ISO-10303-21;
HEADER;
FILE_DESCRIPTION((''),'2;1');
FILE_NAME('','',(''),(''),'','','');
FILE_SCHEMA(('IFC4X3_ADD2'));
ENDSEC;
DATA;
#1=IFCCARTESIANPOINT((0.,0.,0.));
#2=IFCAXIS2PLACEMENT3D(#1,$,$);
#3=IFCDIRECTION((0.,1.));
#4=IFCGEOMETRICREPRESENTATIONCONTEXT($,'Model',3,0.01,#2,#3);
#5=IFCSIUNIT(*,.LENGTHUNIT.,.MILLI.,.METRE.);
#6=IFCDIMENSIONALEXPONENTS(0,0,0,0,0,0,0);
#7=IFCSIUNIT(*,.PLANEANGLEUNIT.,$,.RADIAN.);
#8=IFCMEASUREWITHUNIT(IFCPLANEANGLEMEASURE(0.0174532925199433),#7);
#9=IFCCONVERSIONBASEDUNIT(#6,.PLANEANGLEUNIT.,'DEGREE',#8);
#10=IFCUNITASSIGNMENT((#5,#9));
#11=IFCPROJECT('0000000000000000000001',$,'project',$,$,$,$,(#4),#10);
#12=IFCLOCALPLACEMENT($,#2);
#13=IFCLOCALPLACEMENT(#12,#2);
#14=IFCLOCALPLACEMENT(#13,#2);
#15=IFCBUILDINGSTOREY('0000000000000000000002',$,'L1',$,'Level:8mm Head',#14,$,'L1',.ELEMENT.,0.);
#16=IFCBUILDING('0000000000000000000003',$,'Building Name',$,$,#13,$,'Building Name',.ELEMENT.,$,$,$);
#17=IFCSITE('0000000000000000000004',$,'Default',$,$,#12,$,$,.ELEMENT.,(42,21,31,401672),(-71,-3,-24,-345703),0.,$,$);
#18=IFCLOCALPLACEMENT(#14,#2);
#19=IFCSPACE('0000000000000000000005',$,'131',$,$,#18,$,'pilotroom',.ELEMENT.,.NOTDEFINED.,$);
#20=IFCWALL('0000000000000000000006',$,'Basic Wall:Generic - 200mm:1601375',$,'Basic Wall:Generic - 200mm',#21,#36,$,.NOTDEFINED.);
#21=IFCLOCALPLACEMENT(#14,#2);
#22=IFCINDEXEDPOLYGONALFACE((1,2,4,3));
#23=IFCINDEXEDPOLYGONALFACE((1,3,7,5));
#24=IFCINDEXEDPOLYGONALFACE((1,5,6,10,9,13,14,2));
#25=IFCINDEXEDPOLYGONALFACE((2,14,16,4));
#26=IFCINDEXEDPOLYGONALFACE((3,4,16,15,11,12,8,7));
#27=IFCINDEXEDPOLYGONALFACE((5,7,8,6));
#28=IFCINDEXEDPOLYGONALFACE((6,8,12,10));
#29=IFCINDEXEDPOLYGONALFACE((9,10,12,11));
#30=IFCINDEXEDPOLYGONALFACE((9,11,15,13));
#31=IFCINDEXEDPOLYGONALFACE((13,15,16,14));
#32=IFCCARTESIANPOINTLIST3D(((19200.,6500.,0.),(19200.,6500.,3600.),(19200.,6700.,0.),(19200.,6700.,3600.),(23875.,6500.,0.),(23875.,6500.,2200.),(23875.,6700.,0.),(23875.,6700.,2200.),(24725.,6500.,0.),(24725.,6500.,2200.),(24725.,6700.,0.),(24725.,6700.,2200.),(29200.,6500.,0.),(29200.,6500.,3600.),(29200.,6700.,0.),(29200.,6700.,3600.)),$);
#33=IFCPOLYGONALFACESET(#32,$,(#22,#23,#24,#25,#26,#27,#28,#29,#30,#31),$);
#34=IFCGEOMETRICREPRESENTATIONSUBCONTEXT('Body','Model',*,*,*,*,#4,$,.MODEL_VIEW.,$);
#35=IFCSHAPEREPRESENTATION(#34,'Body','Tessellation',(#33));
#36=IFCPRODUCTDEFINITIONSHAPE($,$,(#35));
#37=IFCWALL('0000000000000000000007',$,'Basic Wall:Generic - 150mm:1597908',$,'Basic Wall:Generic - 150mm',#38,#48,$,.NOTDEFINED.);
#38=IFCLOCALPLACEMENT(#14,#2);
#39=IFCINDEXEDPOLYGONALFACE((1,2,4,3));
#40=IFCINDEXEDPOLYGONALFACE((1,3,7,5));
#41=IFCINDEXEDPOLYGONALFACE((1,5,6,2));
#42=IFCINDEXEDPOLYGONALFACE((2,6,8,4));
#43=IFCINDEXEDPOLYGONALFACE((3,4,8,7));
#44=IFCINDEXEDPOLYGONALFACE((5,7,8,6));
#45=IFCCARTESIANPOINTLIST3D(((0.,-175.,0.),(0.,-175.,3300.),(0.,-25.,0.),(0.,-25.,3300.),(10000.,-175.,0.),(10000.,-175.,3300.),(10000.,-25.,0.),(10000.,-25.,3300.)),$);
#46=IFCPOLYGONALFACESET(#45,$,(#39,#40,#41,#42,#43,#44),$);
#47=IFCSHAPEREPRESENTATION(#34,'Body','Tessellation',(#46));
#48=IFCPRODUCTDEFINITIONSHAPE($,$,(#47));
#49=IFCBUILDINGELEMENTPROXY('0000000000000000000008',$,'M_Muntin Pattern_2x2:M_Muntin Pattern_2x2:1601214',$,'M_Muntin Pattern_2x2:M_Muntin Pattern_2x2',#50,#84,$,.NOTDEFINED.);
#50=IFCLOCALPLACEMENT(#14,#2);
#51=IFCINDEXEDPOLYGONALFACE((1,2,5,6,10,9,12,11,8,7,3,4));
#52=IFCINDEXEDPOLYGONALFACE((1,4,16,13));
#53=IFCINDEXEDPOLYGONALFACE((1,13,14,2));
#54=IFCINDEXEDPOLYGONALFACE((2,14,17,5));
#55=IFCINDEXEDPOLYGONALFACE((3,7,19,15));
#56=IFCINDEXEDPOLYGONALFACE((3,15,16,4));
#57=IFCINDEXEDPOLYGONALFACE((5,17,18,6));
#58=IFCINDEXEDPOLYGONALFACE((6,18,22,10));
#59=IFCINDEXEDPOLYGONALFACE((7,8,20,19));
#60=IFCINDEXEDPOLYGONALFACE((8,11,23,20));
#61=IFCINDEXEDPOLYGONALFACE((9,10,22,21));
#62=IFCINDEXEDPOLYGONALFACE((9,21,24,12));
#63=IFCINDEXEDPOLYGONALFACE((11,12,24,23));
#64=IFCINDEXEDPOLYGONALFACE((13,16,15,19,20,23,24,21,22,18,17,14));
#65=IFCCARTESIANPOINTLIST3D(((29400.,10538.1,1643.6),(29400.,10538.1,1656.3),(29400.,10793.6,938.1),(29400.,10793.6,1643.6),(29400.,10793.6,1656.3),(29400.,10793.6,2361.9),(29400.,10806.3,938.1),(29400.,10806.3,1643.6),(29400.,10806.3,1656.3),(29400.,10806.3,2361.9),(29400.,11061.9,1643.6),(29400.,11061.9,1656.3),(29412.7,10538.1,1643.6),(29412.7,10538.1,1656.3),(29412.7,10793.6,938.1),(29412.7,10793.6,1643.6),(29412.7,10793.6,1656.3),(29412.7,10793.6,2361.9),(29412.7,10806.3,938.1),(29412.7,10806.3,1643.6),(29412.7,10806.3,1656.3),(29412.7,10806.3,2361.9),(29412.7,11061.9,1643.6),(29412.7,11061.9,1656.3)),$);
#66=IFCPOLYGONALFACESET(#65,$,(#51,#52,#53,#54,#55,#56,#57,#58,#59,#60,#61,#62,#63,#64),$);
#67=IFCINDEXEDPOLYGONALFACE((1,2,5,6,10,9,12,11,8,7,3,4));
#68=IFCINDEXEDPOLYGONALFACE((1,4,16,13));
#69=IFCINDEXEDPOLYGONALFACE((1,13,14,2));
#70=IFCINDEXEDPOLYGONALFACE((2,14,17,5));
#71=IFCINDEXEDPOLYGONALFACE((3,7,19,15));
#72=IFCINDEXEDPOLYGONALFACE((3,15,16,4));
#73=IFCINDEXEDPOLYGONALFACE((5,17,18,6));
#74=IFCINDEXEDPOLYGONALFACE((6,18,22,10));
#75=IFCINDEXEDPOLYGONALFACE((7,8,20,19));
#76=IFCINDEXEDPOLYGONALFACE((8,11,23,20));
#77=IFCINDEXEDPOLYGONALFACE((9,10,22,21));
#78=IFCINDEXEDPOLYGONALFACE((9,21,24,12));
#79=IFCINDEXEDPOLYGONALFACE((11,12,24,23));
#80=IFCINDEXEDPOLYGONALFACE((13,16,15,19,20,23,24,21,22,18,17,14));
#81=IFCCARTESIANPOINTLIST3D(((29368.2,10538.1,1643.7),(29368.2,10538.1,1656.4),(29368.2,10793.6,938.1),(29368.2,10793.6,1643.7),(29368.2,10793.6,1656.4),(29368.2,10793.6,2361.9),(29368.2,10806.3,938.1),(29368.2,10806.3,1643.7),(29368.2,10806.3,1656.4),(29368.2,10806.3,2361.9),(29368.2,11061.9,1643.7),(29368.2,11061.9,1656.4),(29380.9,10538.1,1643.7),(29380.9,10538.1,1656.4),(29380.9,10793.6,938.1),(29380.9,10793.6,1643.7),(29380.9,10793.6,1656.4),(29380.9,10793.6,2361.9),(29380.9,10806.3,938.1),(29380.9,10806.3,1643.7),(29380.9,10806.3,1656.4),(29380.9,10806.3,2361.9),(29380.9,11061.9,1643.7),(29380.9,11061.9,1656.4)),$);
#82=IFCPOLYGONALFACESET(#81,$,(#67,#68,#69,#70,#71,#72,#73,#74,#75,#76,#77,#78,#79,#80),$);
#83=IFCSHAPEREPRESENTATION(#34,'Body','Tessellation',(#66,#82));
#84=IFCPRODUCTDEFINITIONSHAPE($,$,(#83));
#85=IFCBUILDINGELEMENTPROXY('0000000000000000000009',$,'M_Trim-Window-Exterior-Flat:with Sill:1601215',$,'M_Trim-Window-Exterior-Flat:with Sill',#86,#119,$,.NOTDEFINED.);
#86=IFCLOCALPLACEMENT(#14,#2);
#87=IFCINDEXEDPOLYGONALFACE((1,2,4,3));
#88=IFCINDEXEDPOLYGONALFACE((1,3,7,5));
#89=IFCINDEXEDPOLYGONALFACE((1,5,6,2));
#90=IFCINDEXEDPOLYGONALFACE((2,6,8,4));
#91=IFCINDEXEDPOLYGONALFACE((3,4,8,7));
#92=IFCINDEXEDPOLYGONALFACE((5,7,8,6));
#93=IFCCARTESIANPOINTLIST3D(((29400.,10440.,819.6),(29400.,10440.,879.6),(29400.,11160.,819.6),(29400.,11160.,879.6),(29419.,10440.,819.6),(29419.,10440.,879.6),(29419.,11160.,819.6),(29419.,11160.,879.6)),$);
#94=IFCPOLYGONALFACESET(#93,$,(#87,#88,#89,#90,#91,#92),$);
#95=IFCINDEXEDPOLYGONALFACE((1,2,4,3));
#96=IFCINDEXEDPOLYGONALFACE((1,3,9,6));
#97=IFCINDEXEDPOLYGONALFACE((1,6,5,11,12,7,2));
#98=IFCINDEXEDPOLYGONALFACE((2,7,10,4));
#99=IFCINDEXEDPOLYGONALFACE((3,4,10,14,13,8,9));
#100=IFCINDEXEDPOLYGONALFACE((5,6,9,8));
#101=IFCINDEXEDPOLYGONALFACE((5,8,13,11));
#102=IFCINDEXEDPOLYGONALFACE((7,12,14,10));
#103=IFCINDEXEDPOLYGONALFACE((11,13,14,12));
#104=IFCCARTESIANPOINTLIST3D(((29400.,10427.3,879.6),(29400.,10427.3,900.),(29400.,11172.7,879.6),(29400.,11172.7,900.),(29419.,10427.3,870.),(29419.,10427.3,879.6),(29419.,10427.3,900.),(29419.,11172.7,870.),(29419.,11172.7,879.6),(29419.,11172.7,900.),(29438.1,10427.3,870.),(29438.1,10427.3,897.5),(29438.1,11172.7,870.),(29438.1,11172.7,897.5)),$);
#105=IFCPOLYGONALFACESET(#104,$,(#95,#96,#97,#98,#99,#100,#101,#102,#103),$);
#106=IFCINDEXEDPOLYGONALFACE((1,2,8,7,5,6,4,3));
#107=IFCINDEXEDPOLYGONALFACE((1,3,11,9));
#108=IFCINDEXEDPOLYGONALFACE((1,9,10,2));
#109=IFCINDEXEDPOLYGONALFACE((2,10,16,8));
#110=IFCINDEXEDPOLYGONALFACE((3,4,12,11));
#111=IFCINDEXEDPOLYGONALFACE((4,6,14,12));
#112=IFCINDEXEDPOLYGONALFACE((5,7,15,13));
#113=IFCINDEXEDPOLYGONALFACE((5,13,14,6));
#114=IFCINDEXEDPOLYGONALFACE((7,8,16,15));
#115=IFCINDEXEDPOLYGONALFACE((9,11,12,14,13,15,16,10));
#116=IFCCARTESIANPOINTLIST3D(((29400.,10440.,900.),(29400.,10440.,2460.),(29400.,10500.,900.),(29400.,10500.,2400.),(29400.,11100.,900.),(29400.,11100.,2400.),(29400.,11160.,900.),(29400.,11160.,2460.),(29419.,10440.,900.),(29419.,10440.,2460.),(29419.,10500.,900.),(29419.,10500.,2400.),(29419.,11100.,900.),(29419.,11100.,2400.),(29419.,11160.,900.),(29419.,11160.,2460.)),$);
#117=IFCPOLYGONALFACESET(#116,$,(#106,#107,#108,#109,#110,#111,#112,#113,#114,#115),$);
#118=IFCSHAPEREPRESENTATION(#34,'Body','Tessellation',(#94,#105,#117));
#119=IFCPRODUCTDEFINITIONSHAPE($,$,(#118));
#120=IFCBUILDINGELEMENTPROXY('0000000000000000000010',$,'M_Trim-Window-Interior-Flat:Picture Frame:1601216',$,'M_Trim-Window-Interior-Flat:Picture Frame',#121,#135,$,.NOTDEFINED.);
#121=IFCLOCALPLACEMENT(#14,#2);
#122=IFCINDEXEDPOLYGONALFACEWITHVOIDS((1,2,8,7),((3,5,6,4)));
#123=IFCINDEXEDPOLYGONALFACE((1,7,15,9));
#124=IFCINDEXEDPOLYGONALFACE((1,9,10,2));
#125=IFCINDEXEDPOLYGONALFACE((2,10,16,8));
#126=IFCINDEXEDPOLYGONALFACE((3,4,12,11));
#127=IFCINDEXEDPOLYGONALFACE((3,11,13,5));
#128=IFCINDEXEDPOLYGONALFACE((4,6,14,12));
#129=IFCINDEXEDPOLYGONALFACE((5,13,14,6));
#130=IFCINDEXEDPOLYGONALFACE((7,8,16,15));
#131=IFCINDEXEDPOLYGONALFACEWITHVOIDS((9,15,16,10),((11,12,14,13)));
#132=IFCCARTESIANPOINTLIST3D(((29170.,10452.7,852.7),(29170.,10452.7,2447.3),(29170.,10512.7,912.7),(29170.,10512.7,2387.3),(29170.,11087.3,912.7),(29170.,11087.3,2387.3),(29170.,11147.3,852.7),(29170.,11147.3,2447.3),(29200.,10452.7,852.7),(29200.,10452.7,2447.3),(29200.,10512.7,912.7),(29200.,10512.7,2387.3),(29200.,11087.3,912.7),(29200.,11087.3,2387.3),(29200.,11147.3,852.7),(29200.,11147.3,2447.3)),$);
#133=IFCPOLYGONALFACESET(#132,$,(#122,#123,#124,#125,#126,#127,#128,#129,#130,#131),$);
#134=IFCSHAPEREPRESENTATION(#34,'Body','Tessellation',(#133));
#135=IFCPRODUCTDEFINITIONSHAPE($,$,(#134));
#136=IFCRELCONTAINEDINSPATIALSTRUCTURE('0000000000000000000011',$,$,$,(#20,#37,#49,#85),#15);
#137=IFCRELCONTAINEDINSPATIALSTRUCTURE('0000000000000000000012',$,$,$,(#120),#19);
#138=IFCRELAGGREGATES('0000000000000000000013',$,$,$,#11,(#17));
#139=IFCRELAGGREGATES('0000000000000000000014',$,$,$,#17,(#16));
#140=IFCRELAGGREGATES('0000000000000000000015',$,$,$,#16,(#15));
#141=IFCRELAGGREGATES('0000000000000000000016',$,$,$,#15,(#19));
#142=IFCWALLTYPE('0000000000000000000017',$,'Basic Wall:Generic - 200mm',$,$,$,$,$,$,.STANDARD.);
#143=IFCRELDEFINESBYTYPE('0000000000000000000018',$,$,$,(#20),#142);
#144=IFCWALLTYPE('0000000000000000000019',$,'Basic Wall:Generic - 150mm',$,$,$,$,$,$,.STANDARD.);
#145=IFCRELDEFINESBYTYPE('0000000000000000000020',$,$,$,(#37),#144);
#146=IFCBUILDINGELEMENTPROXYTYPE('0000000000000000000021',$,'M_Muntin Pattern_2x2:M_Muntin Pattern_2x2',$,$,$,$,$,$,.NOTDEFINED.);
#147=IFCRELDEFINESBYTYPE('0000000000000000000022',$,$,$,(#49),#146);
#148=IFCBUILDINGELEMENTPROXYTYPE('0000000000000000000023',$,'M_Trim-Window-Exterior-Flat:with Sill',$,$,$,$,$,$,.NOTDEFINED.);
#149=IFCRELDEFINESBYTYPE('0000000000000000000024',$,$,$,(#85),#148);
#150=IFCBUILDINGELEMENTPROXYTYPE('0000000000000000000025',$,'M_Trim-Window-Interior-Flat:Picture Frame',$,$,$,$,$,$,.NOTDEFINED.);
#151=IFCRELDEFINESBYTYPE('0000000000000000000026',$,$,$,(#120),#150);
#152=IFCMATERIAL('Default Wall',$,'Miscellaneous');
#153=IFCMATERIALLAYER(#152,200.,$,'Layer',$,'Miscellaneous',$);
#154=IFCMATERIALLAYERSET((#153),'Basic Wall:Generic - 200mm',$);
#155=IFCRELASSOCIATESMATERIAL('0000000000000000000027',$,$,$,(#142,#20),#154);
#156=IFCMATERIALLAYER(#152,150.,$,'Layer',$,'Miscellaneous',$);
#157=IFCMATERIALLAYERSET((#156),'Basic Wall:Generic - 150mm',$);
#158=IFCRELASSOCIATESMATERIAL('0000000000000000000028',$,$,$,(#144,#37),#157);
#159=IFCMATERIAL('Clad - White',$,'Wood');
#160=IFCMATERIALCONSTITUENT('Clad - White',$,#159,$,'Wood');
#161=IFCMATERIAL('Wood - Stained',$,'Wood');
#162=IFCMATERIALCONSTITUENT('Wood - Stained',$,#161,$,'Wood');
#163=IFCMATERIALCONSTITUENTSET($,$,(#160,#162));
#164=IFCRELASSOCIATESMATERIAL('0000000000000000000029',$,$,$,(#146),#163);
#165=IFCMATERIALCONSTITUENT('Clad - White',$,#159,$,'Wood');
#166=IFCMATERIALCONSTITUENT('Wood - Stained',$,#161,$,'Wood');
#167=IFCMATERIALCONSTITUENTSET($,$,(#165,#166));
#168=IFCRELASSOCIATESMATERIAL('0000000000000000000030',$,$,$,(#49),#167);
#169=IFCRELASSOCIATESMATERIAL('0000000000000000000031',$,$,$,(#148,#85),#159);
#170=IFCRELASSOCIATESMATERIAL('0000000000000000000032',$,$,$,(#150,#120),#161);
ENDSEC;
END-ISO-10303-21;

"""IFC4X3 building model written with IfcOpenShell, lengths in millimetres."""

from ifc_helpers import new_model, entity, si_unit, converted_unit, direction, frame, frame_2d, origin, place, context, subcontext, project, spatial, polyline, rectangle, outline, extrude, source, transform, mapped, material, layer, layer_set, constituent, constituent_set, type_object, type_shapes, element, save


model = new_model("IFC4X3")

# Units and contexts
model_context = context("Model", 3, precision=0.01, world=origin(), true_north=direction((0.0, 1.0)))
body_context = subcontext(model_context, "Body", "Model", "MODEL_VIEW")
ifc_project = project(units=[si_unit("LENGTHUNIT", "METRE", prefix="MILLI"), converted_unit("PLANEANGLEUNIT", "DEGREE", entity("IfcPlaneAngleMeasure", 0.0174532925199433), si_unit("PLANEANGLEUNIT", "RADIAN"), dimensions=[0, 0, 0, 0, 0, 0, 0])], contexts=[model_context])

# Site, building, storey
site_placement = place(None, origin())
site = spatial("IfcSite", under=ifc_project, at=site_placement, Name="Default", CompositionType="ELEMENT", RefLatitude=(42, 21, 31, 401672), RefLongitude=(-71, -3, -24, -345703), RefElevation=0.0)
building_placement = place(site_placement, origin())
building = spatial("IfcBuilding", under=site, at=building_placement, Name="Building Name", LongName="Building Name", CompositionType="ELEMENT")
storey_placement = place(building_placement, origin())
storey = spatial("IfcBuildingStorey", under=building, at=storey_placement, Name="L1", ObjectType="Level:8mm Head", LongName="L1", CompositionType="ELEMENT", Elevation=0.0)

# Shared definitions
ifc_material_1 = material(Name="Default Wall", Category="Miscellaneous")
ifc_layer_1 = layer(ifc_material_1, 200.0, Name="Layer", Category="Miscellaneous")
ifc_layer_set_1 = layer_set([ifc_layer_1], Name="Basic Wall:Generic - 200mm")
wall_type_1 = type_object("IfcWallType", Name="Basic Wall:Generic - 200mm", PredefinedType="STANDARD", material=ifc_layer_set_1)

# Wall, opening
wall_1_placement = place(storey_placement, frame((29200.0, 6600.0, 0.0), z_axis=(0.0, 0.0, 1.0), x_axis=(-1.0, 0.0, 0.0)))
wall_1 = element("IfcWall", 1, at=wall_1_placement, inside=storey, type_object=wall_type_1, material=ifc_layer_set_1, Name="Basic Wall:Generic - 200mm:1601375", ObjectType="Basic Wall:Generic - 200mm", PredefinedType="NOTDEFINED", context=body_context, shape_type="SweptSolid", body=[
    extrude(rectangle(XDim=10000.0, YDim=200.0, at=frame_2d((5000.0, 0.0), x_axis=(1.0, 0.0))), origin(), (0.0, 0.0, 1.0), 3600.0),
])
opening_1_placement = place(wall_1_placement, frame((5325.0, 100.0, 0.0)))
element("IfcOpeningElement", 2, at=opening_1_placement, cuts=wall_1, PredefinedType="OPENING", context=body_context, shape_type="SweptSolid", body=[
    extrude(rectangle(XDim=2200.0, YDim=850.0, at=frame_2d((1100.0, 425.0), x_axis=(1.0, 0.0))), frame((0.0, 0.0, 0.0), z_axis=(0.0, -1.0, 0.0), x_axis=(0.0, 0.0, 1.0)), (0.0, 0.0, 1.0), 200.0),
])

# Wall
ifc_layer_2 = layer(ifc_material_1, 150.0, Name="Layer", Category="Miscellaneous")
ifc_layer_set_2 = layer_set([ifc_layer_2], Name="Basic Wall:Generic - 150mm")
wall_type_2 = type_object("IfcWallType", Name="Basic Wall:Generic - 150mm", PredefinedType="STANDARD", material=ifc_layer_set_2)
wall_2_placement = place(storey_placement, frame((0.0, -100.0, 0.0)))
element("IfcWall", 3, at=wall_2_placement, inside=storey, type_object=wall_type_2, material=ifc_layer_set_2, Name="Basic Wall:Generic - 150mm:1597908", ObjectType="Basic Wall:Generic - 150mm", PredefinedType="NOTDEFINED", context=body_context, shape_type="SweptSolid", body=[
    extrude(rectangle(XDim=10000.0, YDim=150.0, at=frame_2d((5000.0, 0.0), x_axis=(-1.0, 0.0))), origin(), (0.0, 0.0, 1.0), 3300.0),
])

# Building element proxies
ifc_material_2 = material(Name="Clad - White", Category="Wood")
ifc_constituent_1 = constituent(ifc_material_2, Name="Clad - White", Category="Wood")
ifc_material_3 = material(Name="Wood - Stained", Category="Wood")
ifc_constituent_2 = constituent(ifc_material_3, Name="Wood - Stained", Category="Wood")
ifc_constituent_set_1 = constituent_set(constituents=[ifc_constituent_1, ifc_constituent_2])
ifc_constituent_3 = constituent(ifc_material_2, Name="Clad - White", Category="Wood")
ifc_constituent_4 = constituent(ifc_material_3, Name="Wood - Stained", Category="Wood")
ifc_constituent_set_2 = constituent_set(constituents=[ifc_constituent_3, ifc_constituent_4])
building_element_proxy_type_1 = type_object("IfcBuildingElementProxyType", Name="M_Muntin Pattern_2x2:M_Muntin Pattern_2x2", PredefinedType="NOTDEFINED", material=ifc_constituent_set_2)
shared_shape_1 = source(origin(), body_context, "Body", "SweptSolid", [
    extrude(outline(polyline([(6.4, -6.4), (711.9, -6.4), (711.9, 6.3), (6.4, 6.3), (6.4, 261.9), (-6.3, 261.9), (-6.3, 6.3), (-711.9, 6.3), (-711.9, -6.4), (-6.3, -6.4), (-6.3, -261.9), (6.4, -261.9), (6.4, -6.4)])), frame((0.0, -22.2, 711.9), z_axis=(0.0, 1.0, 0.0), x_axis=(0.0, 0.0, 1.0)), (0.0, 0.0, 1.0), 12.7),
    extrude(outline(polyline([(6.4, -6.4), (711.9, -6.4), (711.9, 6.3), (6.4, 6.3), (6.4, 261.9), (-6.3, 261.9), (-6.3, 6.3), (-711.9, 6.3), (-711.9, -6.4), (-6.3, -6.4), (-6.3, -261.9), (6.4, -261.9), (6.4, -6.4)])), frame((0.0, 9.5, 711.9), z_axis=(0.0, 1.0, 0.0), x_axis=(0.0, 0.0, 1.0)), (0.0, 0.0, 1.0), 12.7),
])
type_shapes(building_element_proxy_type_1, [shared_shape_1])
proxy_1_placement = place(storey_placement, frame((29390.5, 10800.0, 938.1), z_axis=(0.0, 0.0, 1.0), x_axis=(0.0, 1.0, 0.0)))
element("IfcBuildingElementProxy", 4, at=proxy_1_placement, inside=storey, type_object=building_element_proxy_type_1, material=ifc_constituent_set_1, Name="M_Muntin Pattern_2x2:M_Muntin Pattern_2x2:1601214", ObjectType="M_Muntin Pattern_2x2:M_Muntin Pattern_2x2", PredefinedType="NOTDEFINED", context=body_context, shape_type="MappedRepresentation", body=[
    mapped(shared_shape_1, transform((0.0, 0.0, 0.0), scale=1.0)),
])
building_element_proxy_type_2 = type_object("IfcBuildingElementProxyType", Name="M_Trim-Window-Exterior-Flat:with Sill", PredefinedType="NOTDEFINED", material=ifc_material_2)
shared_shape_2 = source(origin(), body_context, "Body", "SweptSolid", [
    extrude(rectangle(XDim=720.0, YDim=60.0, at=frame_2d((0.0, 0.0), x_axis=(1.0, 0.0))), frame((0.0, -1550.4, 0.0), z_axis=(0.0, 0.0, 1.0), x_axis=(-1.0, 0.0, 0.0)), (0.0, 0.0, 1.0), 19.1),
    extrude(outline(polyline([(-19.0, -15.2), (0.0, -15.2), (0.0, -5.7), (19.0, -5.7), (19.0, 14.8), (0.0, 14.8), (-19.0, 12.3), (-19.0, -15.2)])), frame((-372.7, -1514.8, 19.0), z_axis=(1.0, 0.0, 0.0), x_axis=(0.0, 0.0, -1.0)), (0.0, 0.0, 1.0), 745.4),
    extrude(outline(polyline([(-795.0, -360.0), (765.0, -360.0), (765.0, -300.0), (-735.0, -300.0), (-735.0, 300.0), (765.0, 300.0), (765.0, 360.0), (-795.0, 360.0), (-795.0, -360.0)])), frame((0.0, -735.0, 0.0), z_axis=(0.0, 0.0, 1.0), x_axis=(0.0, -1.0, 0.0)), (0.0, 0.0, 1.0), 19.1),
])
type_shapes(building_element_proxy_type_2, [shared_shape_2])
proxy_2_placement = place(storey_placement, frame((29400.0, 10800.0, 2400.0), z_axis=(1.0, 0.0, 0.0), x_axis=(0.0, 1.0, 0.0)))
element("IfcBuildingElementProxy", 5, at=proxy_2_placement, inside=storey, type_object=building_element_proxy_type_2, material=ifc_material_2, Name="M_Trim-Window-Exterior-Flat:with Sill:1601215", ObjectType="M_Trim-Window-Exterior-Flat:with Sill", PredefinedType="NOTDEFINED", context=body_context, shape_type="MappedRepresentation", body=[
    mapped(shared_shape_2, transform((0.0, 0.0, 0.0), scale=1.0)),
])

# Shared definitions
space_placement = place(storey_placement, origin())
space = spatial("IfcSpace", under=storey, at=space_placement, Name="131", LongName="pilotroom", CompositionType="ELEMENT", PredefinedType="NOTDEFINED")

# Building element proxy
building_element_proxy_type_3 = type_object("IfcBuildingElementProxyType", Name="M_Trim-Window-Interior-Flat:Picture Frame", PredefinedType="NOTDEFINED", material=ifc_material_3)
shared_shape_3 = source(origin(), body_context, "Body", "SweptSolid", [
    extrude(outline(polyline([(-347.3, -797.3), (347.3, -797.3), (347.3, 797.3), (-347.3, 797.3), (-347.3, -797.3)]), holes=[polyline([(-287.3, -737.3), (-287.3, 737.3), (287.3, 737.3), (287.3, -737.3), (-287.3, -737.3)])]), frame((0.0, -750.0, 0.0), z_axis=(0.0, 0.0, 1.0), x_axis=(-1.0, 0.0, 0.0)), (0.0, 0.0, 1.0), 30.0),
])
type_shapes(building_element_proxy_type_3, [shared_shape_3])
proxy_3_placement = place(space_placement, frame((29200.0, 10800.0, 2400.0), z_axis=(-1.0, 0.0, 0.0), x_axis=(0.0, -1.0, 0.0)))
element("IfcBuildingElementProxy", 6, at=proxy_3_placement, inside=space, type_object=building_element_proxy_type_3, material=ifc_material_3, Name="M_Trim-Window-Interior-Flat:Picture Frame:1601216", ObjectType="M_Trim-Window-Interior-Flat:Picture Frame", PredefinedType="NOTDEFINED", context=body_context, shape_type="MappedRepresentation", body=[
    mapped(shared_shape_3, transform((0.0, 0.0, 0.0), scale=1.0)),
])

save(model, "model.ifc")
